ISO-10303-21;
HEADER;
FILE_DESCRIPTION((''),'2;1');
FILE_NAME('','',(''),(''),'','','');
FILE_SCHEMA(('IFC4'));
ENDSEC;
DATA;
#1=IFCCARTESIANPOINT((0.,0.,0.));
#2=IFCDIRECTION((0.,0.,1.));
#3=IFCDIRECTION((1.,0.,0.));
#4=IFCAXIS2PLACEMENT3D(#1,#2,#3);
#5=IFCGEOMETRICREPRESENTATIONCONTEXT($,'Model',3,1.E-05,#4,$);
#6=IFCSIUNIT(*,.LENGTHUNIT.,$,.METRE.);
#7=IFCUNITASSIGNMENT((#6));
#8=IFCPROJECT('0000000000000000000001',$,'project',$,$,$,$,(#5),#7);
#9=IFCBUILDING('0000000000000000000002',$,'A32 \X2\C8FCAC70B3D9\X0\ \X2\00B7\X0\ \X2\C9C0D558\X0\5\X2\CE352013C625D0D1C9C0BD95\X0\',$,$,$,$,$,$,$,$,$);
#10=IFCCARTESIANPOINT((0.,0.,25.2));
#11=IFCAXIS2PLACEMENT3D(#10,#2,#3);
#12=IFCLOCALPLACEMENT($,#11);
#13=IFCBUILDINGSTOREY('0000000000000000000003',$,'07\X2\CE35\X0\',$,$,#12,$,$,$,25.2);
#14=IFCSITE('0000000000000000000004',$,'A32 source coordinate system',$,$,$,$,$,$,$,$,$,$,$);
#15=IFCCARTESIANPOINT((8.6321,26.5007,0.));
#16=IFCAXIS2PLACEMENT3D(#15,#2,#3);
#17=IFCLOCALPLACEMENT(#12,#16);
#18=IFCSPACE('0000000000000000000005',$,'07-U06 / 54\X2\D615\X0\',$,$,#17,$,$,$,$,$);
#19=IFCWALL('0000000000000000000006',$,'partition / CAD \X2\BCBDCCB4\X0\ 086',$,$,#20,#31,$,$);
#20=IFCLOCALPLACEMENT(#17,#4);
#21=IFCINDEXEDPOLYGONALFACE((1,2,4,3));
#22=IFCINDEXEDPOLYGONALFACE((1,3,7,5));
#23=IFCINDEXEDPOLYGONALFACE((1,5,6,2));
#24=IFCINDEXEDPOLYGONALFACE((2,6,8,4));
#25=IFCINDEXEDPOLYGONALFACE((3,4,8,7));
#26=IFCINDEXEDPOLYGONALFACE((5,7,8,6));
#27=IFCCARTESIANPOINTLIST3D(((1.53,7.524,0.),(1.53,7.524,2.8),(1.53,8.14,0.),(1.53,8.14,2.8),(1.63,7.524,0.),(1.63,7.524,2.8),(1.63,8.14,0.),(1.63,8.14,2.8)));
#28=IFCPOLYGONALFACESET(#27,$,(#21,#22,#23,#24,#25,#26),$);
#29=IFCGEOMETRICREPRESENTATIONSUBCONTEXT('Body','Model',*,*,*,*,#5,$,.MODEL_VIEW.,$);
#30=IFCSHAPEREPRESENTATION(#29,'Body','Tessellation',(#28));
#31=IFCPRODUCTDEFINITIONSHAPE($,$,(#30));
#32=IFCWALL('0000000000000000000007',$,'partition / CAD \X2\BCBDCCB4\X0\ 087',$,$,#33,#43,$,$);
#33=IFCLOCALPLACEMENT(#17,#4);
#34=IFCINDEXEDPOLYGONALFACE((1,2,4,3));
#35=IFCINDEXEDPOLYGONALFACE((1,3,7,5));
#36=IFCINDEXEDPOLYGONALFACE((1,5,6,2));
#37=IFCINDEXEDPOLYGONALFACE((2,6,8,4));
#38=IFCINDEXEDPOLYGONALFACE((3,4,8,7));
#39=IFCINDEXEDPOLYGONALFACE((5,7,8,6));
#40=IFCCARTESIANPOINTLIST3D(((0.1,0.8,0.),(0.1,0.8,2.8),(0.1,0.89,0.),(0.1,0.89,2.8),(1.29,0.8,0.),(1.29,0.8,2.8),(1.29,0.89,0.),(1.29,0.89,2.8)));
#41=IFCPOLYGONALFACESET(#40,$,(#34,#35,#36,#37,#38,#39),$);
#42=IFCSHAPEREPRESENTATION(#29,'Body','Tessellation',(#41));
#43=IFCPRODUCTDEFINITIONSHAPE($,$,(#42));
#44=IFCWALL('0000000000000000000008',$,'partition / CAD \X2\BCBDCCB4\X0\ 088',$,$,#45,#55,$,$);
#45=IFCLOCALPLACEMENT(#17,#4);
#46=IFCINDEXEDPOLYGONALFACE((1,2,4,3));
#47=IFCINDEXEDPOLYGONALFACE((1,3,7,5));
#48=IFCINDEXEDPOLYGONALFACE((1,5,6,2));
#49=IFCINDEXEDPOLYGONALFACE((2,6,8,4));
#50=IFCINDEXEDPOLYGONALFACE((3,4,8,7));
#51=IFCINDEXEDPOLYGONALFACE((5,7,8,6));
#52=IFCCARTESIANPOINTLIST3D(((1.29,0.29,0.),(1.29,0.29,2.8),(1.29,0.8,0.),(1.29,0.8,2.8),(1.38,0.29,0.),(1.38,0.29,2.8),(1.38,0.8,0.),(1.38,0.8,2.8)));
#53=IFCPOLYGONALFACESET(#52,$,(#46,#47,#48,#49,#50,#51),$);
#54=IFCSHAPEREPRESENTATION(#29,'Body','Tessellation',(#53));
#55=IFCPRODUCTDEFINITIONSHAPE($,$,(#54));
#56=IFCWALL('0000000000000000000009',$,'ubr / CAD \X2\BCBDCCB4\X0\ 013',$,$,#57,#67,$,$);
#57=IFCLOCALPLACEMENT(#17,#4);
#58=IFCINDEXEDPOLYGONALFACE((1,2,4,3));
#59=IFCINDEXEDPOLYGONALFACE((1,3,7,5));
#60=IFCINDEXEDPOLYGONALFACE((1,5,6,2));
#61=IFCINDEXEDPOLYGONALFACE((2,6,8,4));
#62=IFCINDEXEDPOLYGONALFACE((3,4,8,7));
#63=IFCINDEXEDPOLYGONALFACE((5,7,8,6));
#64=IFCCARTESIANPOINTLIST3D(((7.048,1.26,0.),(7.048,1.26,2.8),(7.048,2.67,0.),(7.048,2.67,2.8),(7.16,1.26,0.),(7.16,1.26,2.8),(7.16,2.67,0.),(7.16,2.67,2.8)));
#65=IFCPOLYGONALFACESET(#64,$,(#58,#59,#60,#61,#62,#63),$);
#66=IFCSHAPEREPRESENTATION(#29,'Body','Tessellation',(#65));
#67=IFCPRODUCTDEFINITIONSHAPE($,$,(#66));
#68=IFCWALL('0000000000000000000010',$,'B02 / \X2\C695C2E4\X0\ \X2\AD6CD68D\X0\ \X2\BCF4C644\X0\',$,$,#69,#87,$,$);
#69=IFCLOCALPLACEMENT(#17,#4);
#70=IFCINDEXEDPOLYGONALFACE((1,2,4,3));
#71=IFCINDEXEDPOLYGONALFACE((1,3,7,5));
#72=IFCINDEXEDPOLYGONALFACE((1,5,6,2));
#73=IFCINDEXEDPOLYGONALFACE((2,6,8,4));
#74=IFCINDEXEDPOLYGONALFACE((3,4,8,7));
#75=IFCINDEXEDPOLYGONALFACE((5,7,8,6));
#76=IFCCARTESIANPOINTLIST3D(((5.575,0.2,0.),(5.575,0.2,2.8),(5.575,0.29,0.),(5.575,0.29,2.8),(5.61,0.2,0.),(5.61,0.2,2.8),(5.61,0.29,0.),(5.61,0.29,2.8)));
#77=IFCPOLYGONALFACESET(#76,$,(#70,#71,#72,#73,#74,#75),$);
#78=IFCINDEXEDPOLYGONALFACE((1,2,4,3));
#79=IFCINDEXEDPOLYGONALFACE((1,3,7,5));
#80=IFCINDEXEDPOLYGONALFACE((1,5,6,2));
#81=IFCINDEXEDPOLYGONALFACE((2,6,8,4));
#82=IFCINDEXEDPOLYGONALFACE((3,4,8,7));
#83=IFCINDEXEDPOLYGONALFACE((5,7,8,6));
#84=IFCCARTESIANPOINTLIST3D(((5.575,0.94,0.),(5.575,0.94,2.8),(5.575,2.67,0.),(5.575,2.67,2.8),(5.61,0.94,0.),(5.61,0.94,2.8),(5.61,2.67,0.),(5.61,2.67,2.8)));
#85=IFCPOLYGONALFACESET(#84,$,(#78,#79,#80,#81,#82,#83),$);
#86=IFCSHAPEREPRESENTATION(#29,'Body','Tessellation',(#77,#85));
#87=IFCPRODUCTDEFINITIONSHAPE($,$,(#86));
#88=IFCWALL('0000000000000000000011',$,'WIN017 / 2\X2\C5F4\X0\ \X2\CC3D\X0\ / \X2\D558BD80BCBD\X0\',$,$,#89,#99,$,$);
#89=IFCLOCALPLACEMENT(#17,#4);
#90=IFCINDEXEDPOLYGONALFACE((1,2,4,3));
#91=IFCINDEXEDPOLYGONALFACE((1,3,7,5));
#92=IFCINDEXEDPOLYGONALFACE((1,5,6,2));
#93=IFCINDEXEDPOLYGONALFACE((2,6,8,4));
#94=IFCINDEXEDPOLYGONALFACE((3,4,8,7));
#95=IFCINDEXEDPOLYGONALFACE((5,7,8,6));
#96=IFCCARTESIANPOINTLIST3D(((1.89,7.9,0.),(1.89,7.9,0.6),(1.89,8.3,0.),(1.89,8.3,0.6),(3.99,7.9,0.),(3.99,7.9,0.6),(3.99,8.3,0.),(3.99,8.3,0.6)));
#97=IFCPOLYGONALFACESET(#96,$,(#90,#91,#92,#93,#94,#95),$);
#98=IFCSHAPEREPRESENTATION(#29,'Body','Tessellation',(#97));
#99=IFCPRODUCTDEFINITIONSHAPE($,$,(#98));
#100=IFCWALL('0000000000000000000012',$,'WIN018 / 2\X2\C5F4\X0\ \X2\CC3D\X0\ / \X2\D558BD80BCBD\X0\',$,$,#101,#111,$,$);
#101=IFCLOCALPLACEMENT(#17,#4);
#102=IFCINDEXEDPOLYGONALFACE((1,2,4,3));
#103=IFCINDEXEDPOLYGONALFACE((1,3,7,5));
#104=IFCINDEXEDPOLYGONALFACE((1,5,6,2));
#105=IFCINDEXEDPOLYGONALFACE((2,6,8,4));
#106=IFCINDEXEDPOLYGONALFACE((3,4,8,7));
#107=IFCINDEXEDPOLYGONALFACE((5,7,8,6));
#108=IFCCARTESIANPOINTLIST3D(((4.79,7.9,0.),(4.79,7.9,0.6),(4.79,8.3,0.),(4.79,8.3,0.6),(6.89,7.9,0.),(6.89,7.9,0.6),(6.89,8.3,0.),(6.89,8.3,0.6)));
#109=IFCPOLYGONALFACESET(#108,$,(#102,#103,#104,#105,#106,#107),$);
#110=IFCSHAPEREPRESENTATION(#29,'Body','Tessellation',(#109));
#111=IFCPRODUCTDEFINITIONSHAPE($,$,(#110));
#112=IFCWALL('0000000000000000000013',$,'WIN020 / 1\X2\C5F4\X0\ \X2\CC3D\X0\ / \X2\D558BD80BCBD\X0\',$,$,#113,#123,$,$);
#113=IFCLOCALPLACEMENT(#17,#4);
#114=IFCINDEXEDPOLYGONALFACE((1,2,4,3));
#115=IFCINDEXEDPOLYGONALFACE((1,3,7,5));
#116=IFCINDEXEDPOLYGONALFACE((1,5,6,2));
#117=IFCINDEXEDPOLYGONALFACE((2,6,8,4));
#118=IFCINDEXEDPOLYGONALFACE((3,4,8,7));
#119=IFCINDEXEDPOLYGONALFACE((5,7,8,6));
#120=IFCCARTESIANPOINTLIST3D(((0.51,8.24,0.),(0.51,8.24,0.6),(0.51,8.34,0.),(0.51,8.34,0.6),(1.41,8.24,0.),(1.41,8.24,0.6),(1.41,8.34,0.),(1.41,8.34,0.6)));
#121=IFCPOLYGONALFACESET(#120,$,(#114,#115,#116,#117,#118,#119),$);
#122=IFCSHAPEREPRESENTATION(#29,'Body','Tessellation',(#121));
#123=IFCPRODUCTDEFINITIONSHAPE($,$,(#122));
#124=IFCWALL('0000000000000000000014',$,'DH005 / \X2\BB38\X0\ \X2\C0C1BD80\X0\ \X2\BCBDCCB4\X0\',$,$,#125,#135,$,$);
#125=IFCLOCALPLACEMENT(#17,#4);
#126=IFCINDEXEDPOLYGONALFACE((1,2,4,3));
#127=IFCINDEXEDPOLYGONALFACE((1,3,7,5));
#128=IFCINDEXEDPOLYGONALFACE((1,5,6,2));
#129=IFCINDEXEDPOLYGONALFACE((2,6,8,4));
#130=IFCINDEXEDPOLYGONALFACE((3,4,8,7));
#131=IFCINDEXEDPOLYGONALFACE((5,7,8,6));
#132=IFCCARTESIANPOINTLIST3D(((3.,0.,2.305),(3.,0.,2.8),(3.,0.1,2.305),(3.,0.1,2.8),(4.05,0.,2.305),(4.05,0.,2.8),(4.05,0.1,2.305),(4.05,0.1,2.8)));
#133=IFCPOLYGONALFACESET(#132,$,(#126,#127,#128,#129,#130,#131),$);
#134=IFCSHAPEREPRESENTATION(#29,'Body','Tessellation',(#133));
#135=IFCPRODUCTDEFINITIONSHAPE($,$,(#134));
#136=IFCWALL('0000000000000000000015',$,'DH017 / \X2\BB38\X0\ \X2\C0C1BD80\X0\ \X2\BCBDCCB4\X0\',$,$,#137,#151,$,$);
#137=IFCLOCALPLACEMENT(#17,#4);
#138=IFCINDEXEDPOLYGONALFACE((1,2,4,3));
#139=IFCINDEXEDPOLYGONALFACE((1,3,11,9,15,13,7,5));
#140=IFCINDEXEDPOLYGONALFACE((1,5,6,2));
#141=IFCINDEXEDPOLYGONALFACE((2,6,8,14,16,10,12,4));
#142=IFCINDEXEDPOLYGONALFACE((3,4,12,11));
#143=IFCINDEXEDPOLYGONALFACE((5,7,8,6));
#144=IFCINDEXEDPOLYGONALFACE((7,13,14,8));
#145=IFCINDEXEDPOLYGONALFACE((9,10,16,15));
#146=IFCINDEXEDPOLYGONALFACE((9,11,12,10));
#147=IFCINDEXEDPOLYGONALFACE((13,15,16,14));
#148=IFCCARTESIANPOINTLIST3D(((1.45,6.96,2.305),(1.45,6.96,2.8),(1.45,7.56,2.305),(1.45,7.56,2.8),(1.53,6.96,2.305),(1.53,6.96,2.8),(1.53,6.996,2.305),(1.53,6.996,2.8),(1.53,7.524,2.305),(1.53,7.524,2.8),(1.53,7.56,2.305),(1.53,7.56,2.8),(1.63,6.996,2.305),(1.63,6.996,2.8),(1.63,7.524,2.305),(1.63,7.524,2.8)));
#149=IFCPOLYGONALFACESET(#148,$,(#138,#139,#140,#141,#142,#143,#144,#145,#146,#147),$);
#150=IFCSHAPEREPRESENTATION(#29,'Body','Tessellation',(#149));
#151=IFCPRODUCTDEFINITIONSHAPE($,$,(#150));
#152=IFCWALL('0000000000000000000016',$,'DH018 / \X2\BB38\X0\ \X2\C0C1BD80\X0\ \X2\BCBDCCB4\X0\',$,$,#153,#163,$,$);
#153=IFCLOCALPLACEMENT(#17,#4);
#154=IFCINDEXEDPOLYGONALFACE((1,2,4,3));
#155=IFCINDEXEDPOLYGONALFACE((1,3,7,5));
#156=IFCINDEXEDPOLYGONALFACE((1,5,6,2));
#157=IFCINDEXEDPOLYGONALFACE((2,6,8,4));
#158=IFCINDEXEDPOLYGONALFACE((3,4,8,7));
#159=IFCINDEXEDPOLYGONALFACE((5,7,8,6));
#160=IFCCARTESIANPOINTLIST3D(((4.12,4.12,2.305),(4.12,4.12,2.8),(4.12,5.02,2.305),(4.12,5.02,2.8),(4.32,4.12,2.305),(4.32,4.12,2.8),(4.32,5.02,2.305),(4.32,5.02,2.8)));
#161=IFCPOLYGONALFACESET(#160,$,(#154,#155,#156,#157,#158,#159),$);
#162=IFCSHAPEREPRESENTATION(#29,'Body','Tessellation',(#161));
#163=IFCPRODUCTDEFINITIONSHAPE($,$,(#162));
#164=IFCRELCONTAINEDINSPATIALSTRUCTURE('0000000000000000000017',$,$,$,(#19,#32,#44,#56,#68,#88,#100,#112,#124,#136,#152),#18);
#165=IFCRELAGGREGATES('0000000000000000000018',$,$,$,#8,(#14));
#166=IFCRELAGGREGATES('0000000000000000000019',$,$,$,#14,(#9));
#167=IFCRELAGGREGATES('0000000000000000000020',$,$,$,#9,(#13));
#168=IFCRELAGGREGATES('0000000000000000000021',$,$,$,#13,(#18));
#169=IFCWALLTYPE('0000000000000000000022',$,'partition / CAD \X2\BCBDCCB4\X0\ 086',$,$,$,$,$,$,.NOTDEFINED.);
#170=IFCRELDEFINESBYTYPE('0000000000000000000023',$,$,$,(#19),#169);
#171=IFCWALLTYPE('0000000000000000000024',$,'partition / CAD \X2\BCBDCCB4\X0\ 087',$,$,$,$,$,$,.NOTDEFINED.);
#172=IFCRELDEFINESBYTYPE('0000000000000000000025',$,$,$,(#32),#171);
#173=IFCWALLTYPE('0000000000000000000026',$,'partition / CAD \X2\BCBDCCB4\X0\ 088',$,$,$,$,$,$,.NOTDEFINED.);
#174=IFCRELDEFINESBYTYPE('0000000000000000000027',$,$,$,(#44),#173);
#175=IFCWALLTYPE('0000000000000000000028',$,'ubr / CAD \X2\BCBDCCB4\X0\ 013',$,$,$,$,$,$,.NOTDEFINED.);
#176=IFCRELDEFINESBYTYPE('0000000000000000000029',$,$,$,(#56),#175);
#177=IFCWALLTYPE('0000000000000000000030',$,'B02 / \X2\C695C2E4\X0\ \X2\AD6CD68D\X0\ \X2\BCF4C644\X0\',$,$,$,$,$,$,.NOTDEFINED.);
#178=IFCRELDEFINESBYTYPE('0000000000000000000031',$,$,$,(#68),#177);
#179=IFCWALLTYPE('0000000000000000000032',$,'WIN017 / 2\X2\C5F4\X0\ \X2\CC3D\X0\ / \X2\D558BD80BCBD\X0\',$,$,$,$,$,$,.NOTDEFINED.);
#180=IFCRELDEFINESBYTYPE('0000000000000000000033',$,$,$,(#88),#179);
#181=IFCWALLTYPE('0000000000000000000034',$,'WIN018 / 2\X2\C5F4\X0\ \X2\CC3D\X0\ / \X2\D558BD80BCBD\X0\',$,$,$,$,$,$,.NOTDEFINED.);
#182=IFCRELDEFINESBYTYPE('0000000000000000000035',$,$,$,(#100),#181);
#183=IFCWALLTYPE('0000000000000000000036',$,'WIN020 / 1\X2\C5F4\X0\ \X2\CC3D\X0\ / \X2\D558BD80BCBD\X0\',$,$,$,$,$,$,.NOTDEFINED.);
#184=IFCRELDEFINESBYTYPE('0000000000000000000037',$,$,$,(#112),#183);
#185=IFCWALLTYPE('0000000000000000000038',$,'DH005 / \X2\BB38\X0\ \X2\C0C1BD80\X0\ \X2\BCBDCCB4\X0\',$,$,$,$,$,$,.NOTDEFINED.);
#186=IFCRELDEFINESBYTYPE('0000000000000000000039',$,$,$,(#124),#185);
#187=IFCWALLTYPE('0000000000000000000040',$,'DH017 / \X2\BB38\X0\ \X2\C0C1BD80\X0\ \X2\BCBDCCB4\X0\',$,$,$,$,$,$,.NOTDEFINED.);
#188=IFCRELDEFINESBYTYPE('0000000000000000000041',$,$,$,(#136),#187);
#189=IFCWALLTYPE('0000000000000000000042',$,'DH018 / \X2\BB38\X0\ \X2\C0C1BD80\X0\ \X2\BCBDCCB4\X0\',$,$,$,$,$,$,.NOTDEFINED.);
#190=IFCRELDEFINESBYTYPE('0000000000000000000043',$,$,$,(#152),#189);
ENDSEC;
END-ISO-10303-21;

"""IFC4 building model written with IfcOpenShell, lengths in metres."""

from ifc_helpers import new_model, si_unit, frame, origin, origin_with_axes, place, context, subcontext, project, spatial, polyline, outline, extrude, source, transform, mapped, type_object, type_shapes, element, save


model = new_model("IFC4")

# Units and contexts
model_context = context("Model", 3, precision=1e-05, world=origin_with_axes())
body_context = subcontext(model_context, "Body", "Model", "MODEL_VIEW")
ifc_project = project(units=[si_unit("LENGTHUNIT", "METRE")], contexts=[model_context])

# Site, building, storey, space
site = spatial("IfcSite", under=ifc_project, Name="A32 source coordinate system")
building = spatial("IfcBuilding", under=site, Name="A32 주거동 · 지하5층–옥탑지붕")
storey_placement = place(None, frame((0.0, 0.0, 25.2), z_axis=(0.0, 0.0, 1.0), x_axis=(1.0, 0.0, 0.0)))
storey = spatial("IfcBuildingStorey", under=building, at=storey_placement, Name="07층", Elevation=25.2)
space_placement = place(storey_placement, frame((8.6321, 26.5007, 0.0), z_axis=(0.0, 0.0, 1.0), x_axis=(1.0, 0.0, 0.0)))
space = spatial("IfcSpace", under=storey, at=space_placement, Name="07-U06 / 54형")

# Walls
wall_type_1 = type_object("IfcWallType", Name="partition / CAD 벽체 086", PredefinedType="NOTDEFINED")
shared_shape_1 = source(origin(), body_context, "Body", "SweptSolid", [
    extrude(outline(polyline([(1.53, 7.524), (1.53, 8.14), (1.63, 8.14), (1.63, 7.524), (1.53, 7.524)])), origin(), (0.0, 0.0, 1.0), 2.8),
])
type_shapes(wall_type_1, [shared_shape_1])
wall_1_placement = place(space_placement, origin_with_axes())
element("IfcWall", 1, at=wall_1_placement, inside=space, type_object=wall_type_1, Name="partition / CAD 벽체 086", context=body_context, shape_type="MappedRepresentation", body=[
    mapped(shared_shape_1, transform((0.0, 0.0, 0.0), scale=1.0)),
])
wall_type_2 = type_object("IfcWallType", Name="partition / CAD 벽체 087", PredefinedType="NOTDEFINED")
shared_shape_2 = source(origin(), body_context, "Body", "SweptSolid", [
    extrude(outline(polyline([(1.29, 0.8), (0.1, 0.8), (0.1, 0.89), (1.29, 0.89), (1.29, 0.8)])), origin(), (0.0, 0.0, 1.0), 2.8),
])
type_shapes(wall_type_2, [shared_shape_2])
wall_2_placement = place(space_placement, origin_with_axes())
element("IfcWall", 2, at=wall_2_placement, inside=space, type_object=wall_type_2, Name="partition / CAD 벽체 087", context=body_context, shape_type="MappedRepresentation", body=[
    mapped(shared_shape_2, transform((0.0, 0.0, 0.0), scale=1.0)),
])
wall_type_3 = type_object("IfcWallType", Name="partition / CAD 벽체 088", PredefinedType="NOTDEFINED")
shared_shape_3 = source(origin(), body_context, "Body", "SweptSolid", [
    extrude(outline(polyline([(1.29, 0.29), (1.29, 0.8), (1.38, 0.8), (1.38, 0.29), (1.29, 0.29)])), origin(), (0.0, 0.0, 1.0), 2.8),
])
type_shapes(wall_type_3, [shared_shape_3])
wall_3_placement = place(space_placement, origin_with_axes())
element("IfcWall", 3, at=wall_3_placement, inside=space, type_object=wall_type_3, Name="partition / CAD 벽체 088", context=body_context, shape_type="MappedRepresentation", body=[
    mapped(shared_shape_3, transform((0.0, 0.0, 0.0), scale=1.0)),
])
wall_type_4 = type_object("IfcWallType", Name="ubr / CAD 벽체 013", PredefinedType="NOTDEFINED")
shared_shape_4 = source(origin(), body_context, "Body", "SweptSolid", [
    extrude(outline(polyline([(7.16, 1.26), (7.048, 1.26), (7.048, 2.67), (7.16, 2.67), (7.16, 1.26)])), origin(), (0.0, 0.0, 1.0), 2.8),
])
type_shapes(wall_type_4, [shared_shape_4])
wall_4_placement = place(space_placement, origin_with_axes())
element("IfcWall", 4, at=wall_4_placement, inside=space, type_object=wall_type_4, Name="ubr / CAD 벽체 013", context=body_context, shape_type="MappedRepresentation", body=[
    mapped(shared_shape_4, transform((0.0, 0.0, 0.0), scale=1.0)),
])
wall_type_5 = type_object("IfcWallType", Name="B02 / 욕실 구획 보완", PredefinedType="NOTDEFINED")
shared_shape_5 = source(origin(), body_context, "Body", "SweptSolid", [
    extrude(outline(polyline([(5.575, 0.2), (5.575, 0.29), (5.61, 0.29), (5.61, 0.2), (5.575, 0.2)])), origin(), (0.0, 0.0, 1.0), 2.8),
    extrude(outline(polyline([(5.575, 0.94), (5.575, 2.67), (5.61, 2.67), (5.61, 0.94), (5.575, 0.94)])), origin(), (0.0, 0.0, 1.0), 2.8),
])
type_shapes(wall_type_5, [shared_shape_5])
wall_5_placement = place(space_placement, origin_with_axes())
element("IfcWall", 5, at=wall_5_placement, inside=space, type_object=wall_type_5, Name="B02 / 욕실 구획 보완", context=body_context, shape_type="MappedRepresentation", body=[
    mapped(shared_shape_5, transform((0.0, 0.0, 0.0), scale=1.0)),
])
wall_type_6 = type_object("IfcWallType", Name="WIN017 / 2열 창 / 하부벽", PredefinedType="NOTDEFINED")
shared_shape_6 = source(origin(), body_context, "Body", "SweptSolid", [
    extrude(outline(polyline([(3.99, 8.3), (3.99, 7.9), (1.89, 7.9), (1.89, 8.3), (3.99, 8.3)])), origin(), (0.0, 0.0, 1.0), 0.6),
])
type_shapes(wall_type_6, [shared_shape_6])
wall_6_placement = place(space_placement, origin_with_axes())
element("IfcWall", 6, at=wall_6_placement, inside=space, type_object=wall_type_6, Name="WIN017 / 2열 창 / 하부벽", context=body_context, shape_type="MappedRepresentation", body=[
    mapped(shared_shape_6, transform((0.0, 0.0, 0.0), scale=1.0)),
])
wall_type_7 = type_object("IfcWallType", Name="WIN018 / 2열 창 / 하부벽", PredefinedType="NOTDEFINED")
shared_shape_7 = source(origin(), body_context, "Body", "SweptSolid", [
    extrude(outline(polyline([(6.89, 8.3), (6.89, 7.9), (4.79, 7.9), (4.79, 8.3), (6.89, 8.3)])), origin(), (0.0, 0.0, 1.0), 0.6),
])
type_shapes(wall_type_7, [shared_shape_7])
wall_7_placement = place(space_placement, origin_with_axes())
element("IfcWall", 7, at=wall_7_placement, inside=space, type_object=wall_type_7, Name="WIN018 / 2열 창 / 하부벽", context=body_context, shape_type="MappedRepresentation", body=[
    mapped(shared_shape_7, transform((0.0, 0.0, 0.0), scale=1.0)),
])
wall_type_8 = type_object("IfcWallType", Name="WIN020 / 1열 창 / 하부벽", PredefinedType="NOTDEFINED")
shared_shape_8 = source(origin(), body_context, "Body", "SweptSolid", [
    extrude(outline(polyline([(1.41, 8.34), (1.41, 8.24), (0.51, 8.24), (0.51, 8.34), (1.41, 8.34)])), origin(), (0.0, 0.0, 1.0), 0.6),
])
type_shapes(wall_type_8, [shared_shape_8])
wall_8_placement = place(space_placement, origin_with_axes())
element("IfcWall", 8, at=wall_8_placement, inside=space, type_object=wall_type_8, Name="WIN020 / 1열 창 / 하부벽", context=body_context, shape_type="MappedRepresentation", body=[
    mapped(shared_shape_8, transform((0.0, 0.0, 0.0), scale=1.0)),
])
wall_type_9 = type_object("IfcWallType", Name="DH005 / 문 상부 벽체", PredefinedType="NOTDEFINED")
shared_shape_9 = source(origin(), body_context, "Body", "SweptSolid", [
    extrude(outline(polyline([(4.05, 0.0), (3.0, 0.0), (3.0, 0.1), (4.05, 0.1), (4.05, 0.0)])), frame((0.0, 0.0, 2.305)), (0.0, 0.0, 1.0), 0.495),
])
type_shapes(wall_type_9, [shared_shape_9])
wall_9_placement = place(space_placement, origin_with_axes())
element("IfcWall", 9, at=wall_9_placement, inside=space, type_object=wall_type_9, Name="DH005 / 문 상부 벽체", context=body_context, shape_type="MappedRepresentation", body=[
    mapped(shared_shape_9, transform((0.0, 0.0, 0.0), scale=1.0)),
])
wall_type_10 = type_object("IfcWallType", Name="DH017 / 문 상부 벽체", PredefinedType="NOTDEFINED")
shared_shape_10 = source(origin(), body_context, "Body", "SweptSolid", [
    extrude(outline(polyline([(1.63, 7.524), (1.63, 6.996), (1.53, 6.996), (1.53, 6.96), (1.45, 6.96), (1.45, 7.56), (1.53, 7.56), (1.53, 7.524), (1.63, 7.524)])), frame((0.0, 0.0, 2.305)), (0.0, 0.0, 1.0), 0.495),
])
type_shapes(wall_type_10, [shared_shape_10])
wall_10_placement = place(space_placement, origin_with_axes())
element("IfcWall", 10, at=wall_10_placement, inside=space, type_object=wall_type_10, Name="DH017 / 문 상부 벽체", context=body_context, shape_type="MappedRepresentation", body=[
    mapped(shared_shape_10, transform((0.0, 0.0, 0.0), scale=1.0)),
])
wall_type_11 = type_object("IfcWallType", Name="DH018 / 문 상부 벽체", PredefinedType="NOTDEFINED")
shared_shape_11 = source(origin(), body_context, "Body", "SweptSolid", [
    extrude(outline(polyline([(4.32, 4.12), (4.12, 4.12), (4.12, 5.02), (4.32, 5.02), (4.32, 4.12)])), frame((0.0, 0.0, 2.305)), (0.0, 0.0, 1.0), 0.495),
])
type_shapes(wall_type_11, [shared_shape_11])
wall_11_placement = place(space_placement, origin_with_axes())
element("IfcWall", 11, at=wall_11_placement, inside=space, type_object=wall_type_11, Name="DH018 / 문 상부 벽체", context=body_context, shape_type="MappedRepresentation", body=[
    mapped(shared_shape_11, transform((0.0, 0.0, 0.0), scale=1.0)),
])

save(model, "model.ifc")
